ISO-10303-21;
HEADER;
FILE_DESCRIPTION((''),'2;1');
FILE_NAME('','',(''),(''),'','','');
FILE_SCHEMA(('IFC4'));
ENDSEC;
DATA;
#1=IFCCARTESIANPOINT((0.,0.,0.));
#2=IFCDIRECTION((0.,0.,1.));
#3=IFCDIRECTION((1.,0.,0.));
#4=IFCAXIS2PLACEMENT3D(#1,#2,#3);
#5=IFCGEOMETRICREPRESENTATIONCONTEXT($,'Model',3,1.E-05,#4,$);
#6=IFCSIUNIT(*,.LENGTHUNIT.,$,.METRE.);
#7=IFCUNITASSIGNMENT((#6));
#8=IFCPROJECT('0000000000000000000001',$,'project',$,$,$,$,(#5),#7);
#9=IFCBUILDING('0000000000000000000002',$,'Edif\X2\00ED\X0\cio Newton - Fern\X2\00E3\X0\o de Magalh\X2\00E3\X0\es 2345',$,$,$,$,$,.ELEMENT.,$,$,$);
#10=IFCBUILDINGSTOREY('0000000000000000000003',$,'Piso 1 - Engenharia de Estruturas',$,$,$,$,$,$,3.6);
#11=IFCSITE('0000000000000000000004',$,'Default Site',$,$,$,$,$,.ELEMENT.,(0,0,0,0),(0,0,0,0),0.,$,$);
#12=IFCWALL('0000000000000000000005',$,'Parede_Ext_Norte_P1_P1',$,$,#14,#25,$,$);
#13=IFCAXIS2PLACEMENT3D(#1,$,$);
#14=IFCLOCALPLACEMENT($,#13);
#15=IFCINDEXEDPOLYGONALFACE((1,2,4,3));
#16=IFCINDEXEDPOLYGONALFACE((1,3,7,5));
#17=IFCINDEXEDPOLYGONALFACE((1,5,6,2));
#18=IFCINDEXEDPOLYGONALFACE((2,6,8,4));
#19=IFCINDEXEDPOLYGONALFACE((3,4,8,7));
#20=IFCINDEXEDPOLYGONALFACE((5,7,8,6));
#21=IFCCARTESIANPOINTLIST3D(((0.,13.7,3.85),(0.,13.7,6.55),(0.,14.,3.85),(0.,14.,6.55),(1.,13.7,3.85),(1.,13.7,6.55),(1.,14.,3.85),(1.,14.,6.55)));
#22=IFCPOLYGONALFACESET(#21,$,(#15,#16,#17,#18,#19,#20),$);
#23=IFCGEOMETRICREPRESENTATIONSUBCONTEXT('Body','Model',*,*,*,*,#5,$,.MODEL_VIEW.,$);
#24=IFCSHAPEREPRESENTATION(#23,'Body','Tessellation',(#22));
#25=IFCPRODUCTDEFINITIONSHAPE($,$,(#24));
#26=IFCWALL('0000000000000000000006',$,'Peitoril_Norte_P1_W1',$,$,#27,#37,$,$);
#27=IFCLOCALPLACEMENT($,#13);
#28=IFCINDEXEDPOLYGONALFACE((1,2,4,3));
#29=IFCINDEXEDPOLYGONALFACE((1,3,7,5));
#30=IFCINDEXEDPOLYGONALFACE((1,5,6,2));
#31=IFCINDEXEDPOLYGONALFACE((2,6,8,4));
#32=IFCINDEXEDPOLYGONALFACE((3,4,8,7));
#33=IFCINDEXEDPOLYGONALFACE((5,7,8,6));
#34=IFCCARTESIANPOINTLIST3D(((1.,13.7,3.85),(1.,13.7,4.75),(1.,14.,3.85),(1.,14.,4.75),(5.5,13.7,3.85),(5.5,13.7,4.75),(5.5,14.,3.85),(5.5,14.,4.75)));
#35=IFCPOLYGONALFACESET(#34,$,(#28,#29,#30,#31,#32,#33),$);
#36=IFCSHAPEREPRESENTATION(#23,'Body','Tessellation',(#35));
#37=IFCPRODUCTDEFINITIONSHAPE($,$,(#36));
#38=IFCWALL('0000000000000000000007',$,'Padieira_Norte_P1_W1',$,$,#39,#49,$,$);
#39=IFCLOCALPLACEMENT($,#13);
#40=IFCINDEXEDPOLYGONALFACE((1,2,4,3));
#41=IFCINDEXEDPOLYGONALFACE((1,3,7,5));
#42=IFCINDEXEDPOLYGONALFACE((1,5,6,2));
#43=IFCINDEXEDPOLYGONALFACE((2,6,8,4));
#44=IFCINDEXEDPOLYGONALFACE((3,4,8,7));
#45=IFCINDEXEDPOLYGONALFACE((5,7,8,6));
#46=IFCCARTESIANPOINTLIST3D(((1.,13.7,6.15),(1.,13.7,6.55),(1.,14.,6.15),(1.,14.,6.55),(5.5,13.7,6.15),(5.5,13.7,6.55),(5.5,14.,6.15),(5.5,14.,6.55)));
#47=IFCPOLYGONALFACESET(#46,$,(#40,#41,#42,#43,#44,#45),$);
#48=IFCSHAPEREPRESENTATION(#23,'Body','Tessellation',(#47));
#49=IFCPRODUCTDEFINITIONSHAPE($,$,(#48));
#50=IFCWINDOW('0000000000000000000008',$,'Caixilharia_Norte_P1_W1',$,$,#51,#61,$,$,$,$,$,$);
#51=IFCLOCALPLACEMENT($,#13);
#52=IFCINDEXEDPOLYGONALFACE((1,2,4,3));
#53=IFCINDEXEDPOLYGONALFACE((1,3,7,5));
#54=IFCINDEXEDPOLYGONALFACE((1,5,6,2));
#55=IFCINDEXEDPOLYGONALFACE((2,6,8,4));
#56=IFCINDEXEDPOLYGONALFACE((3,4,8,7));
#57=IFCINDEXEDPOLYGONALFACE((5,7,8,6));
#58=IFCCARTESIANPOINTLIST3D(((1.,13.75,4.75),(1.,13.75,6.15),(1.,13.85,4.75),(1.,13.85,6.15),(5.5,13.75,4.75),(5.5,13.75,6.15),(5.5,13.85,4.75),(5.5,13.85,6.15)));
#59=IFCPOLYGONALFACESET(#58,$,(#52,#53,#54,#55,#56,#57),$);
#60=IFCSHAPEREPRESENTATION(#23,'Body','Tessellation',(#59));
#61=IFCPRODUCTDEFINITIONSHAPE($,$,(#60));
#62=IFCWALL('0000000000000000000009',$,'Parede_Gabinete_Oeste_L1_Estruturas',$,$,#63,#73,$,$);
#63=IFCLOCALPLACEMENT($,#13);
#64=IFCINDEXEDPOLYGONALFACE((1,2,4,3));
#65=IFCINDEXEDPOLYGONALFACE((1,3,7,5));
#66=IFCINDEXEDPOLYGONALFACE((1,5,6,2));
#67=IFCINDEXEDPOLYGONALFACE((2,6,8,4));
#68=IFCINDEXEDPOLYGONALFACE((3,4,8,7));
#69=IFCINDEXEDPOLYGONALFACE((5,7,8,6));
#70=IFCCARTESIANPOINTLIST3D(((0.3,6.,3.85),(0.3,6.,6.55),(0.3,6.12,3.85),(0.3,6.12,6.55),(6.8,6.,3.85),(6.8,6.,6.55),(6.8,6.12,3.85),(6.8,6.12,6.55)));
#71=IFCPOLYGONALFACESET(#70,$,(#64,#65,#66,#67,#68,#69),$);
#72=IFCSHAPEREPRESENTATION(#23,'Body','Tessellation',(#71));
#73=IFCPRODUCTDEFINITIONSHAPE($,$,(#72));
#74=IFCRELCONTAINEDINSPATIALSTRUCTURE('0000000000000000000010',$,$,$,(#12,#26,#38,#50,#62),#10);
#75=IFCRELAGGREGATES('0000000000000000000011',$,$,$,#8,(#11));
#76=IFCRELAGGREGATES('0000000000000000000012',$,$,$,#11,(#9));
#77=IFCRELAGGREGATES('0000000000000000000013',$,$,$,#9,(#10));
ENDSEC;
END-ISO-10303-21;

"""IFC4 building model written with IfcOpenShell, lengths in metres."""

from ifc_helpers import new_model, si_unit, frame, frame_2d, origin_with_axes, place, context, subcontext, project, spatial, rectangle, extrude, element, save


model = new_model("IFC4")

# Units and contexts
model_context = context("Model", 3, precision=1e-05, world=origin_with_axes())
body_context = subcontext(model_context, "Body", "Model", "MODEL_VIEW")
ifc_project = project(units=[si_unit("LENGTHUNIT", "METRE")], contexts=[model_context])

# Site, building, storey
site = spatial("IfcSite", under=ifc_project, Name="Default Site", CompositionType="ELEMENT", RefLatitude=(0, 0, 0, 0), RefLongitude=(0, 0, 0, 0), RefElevation=0.0)
building = spatial("IfcBuilding", under=site, Name="Edifício Newton - Fernão de Magalhães 2345", CompositionType="ELEMENT")
storey = spatial("IfcBuildingStorey", under=building, Name="Piso 1 - Engenharia de Estruturas", Elevation=3.6)

# Walls
wall_1_placement = place(None, frame((0.0, 13.7, 3.85), z_axis=(0.0, 0.0, 1.0), x_axis=(1.0, 0.0, 0.0)))
element("IfcWall", 1, at=wall_1_placement, inside=storey, Name="Parede_Ext_Norte_P1_P1", context=body_context, shape_type="SweptSolid", body=[
    extrude(rectangle(XDim=1.0, YDim=0.3, at=frame_2d((0.5, 0.15))), origin_with_axes(), (0.0, 0.0, 1.0), 2.7),
])
wall_2_placement = place(None, frame((1.0, 13.7, 3.85), z_axis=(0.0, 0.0, 1.0), x_axis=(1.0, 0.0, 0.0)))
element("IfcWall", 2, at=wall_2_placement, inside=storey, Name="Peitoril_Norte_P1_W1", context=body_context, shape_type="SweptSolid", body=[
    extrude(rectangle(XDim=4.5, YDim=0.3, at=frame_2d((2.25, 0.15))), origin_with_axes(), (0.0, 0.0, 1.0), 0.9),
])
wall_3_placement = place(None, frame((1.0, 13.7, 6.15), z_axis=(0.0, 0.0, 1.0), x_axis=(1.0, 0.0, 0.0)))
element("IfcWall", 3, at=wall_3_placement, inside=storey, Name="Padieira_Norte_P1_W1", context=body_context, shape_type="SweptSolid", body=[
    extrude(rectangle(XDim=4.5, YDim=0.3, at=frame_2d((2.25, 0.15))), origin_with_axes(), (0.0, 0.0, 1.0), 0.4),
])

# Window
window_1_placement = place(None, frame((1.0, 13.75, 4.75), z_axis=(0.0, 0.0, 1.0), x_axis=(1.0, 0.0, 0.0)))
element("IfcWindow", 4, at=window_1_placement, inside=storey, Name="Caixilharia_Norte_P1_W1", context=body_context, shape_type="SweptSolid", body=[
    extrude(rectangle(XDim=4.5, YDim=0.1, at=frame_2d((2.25, 0.05))), origin_with_axes(), (0.0, 0.0, 1.0), 1.4),
])

# Wall
wall_4_placement = place(None, frame((0.3, 6.0, 3.85), z_axis=(0.0, 0.0, 1.0), x_axis=(1.0, 0.0, 0.0)))
element("IfcWall", 5, at=wall_4_placement, inside=storey, Name="Parede_Gabinete_Oeste_L1_Estruturas", context=body_context, shape_type="SweptSolid", body=[
    extrude(rectangle(XDim=6.5, YDim=0.12, at=frame_2d((3.25, 0.06))), origin_with_axes(), (0.0, 0.0, 1.0), 2.7),
])

save(model, "model.ifc")
